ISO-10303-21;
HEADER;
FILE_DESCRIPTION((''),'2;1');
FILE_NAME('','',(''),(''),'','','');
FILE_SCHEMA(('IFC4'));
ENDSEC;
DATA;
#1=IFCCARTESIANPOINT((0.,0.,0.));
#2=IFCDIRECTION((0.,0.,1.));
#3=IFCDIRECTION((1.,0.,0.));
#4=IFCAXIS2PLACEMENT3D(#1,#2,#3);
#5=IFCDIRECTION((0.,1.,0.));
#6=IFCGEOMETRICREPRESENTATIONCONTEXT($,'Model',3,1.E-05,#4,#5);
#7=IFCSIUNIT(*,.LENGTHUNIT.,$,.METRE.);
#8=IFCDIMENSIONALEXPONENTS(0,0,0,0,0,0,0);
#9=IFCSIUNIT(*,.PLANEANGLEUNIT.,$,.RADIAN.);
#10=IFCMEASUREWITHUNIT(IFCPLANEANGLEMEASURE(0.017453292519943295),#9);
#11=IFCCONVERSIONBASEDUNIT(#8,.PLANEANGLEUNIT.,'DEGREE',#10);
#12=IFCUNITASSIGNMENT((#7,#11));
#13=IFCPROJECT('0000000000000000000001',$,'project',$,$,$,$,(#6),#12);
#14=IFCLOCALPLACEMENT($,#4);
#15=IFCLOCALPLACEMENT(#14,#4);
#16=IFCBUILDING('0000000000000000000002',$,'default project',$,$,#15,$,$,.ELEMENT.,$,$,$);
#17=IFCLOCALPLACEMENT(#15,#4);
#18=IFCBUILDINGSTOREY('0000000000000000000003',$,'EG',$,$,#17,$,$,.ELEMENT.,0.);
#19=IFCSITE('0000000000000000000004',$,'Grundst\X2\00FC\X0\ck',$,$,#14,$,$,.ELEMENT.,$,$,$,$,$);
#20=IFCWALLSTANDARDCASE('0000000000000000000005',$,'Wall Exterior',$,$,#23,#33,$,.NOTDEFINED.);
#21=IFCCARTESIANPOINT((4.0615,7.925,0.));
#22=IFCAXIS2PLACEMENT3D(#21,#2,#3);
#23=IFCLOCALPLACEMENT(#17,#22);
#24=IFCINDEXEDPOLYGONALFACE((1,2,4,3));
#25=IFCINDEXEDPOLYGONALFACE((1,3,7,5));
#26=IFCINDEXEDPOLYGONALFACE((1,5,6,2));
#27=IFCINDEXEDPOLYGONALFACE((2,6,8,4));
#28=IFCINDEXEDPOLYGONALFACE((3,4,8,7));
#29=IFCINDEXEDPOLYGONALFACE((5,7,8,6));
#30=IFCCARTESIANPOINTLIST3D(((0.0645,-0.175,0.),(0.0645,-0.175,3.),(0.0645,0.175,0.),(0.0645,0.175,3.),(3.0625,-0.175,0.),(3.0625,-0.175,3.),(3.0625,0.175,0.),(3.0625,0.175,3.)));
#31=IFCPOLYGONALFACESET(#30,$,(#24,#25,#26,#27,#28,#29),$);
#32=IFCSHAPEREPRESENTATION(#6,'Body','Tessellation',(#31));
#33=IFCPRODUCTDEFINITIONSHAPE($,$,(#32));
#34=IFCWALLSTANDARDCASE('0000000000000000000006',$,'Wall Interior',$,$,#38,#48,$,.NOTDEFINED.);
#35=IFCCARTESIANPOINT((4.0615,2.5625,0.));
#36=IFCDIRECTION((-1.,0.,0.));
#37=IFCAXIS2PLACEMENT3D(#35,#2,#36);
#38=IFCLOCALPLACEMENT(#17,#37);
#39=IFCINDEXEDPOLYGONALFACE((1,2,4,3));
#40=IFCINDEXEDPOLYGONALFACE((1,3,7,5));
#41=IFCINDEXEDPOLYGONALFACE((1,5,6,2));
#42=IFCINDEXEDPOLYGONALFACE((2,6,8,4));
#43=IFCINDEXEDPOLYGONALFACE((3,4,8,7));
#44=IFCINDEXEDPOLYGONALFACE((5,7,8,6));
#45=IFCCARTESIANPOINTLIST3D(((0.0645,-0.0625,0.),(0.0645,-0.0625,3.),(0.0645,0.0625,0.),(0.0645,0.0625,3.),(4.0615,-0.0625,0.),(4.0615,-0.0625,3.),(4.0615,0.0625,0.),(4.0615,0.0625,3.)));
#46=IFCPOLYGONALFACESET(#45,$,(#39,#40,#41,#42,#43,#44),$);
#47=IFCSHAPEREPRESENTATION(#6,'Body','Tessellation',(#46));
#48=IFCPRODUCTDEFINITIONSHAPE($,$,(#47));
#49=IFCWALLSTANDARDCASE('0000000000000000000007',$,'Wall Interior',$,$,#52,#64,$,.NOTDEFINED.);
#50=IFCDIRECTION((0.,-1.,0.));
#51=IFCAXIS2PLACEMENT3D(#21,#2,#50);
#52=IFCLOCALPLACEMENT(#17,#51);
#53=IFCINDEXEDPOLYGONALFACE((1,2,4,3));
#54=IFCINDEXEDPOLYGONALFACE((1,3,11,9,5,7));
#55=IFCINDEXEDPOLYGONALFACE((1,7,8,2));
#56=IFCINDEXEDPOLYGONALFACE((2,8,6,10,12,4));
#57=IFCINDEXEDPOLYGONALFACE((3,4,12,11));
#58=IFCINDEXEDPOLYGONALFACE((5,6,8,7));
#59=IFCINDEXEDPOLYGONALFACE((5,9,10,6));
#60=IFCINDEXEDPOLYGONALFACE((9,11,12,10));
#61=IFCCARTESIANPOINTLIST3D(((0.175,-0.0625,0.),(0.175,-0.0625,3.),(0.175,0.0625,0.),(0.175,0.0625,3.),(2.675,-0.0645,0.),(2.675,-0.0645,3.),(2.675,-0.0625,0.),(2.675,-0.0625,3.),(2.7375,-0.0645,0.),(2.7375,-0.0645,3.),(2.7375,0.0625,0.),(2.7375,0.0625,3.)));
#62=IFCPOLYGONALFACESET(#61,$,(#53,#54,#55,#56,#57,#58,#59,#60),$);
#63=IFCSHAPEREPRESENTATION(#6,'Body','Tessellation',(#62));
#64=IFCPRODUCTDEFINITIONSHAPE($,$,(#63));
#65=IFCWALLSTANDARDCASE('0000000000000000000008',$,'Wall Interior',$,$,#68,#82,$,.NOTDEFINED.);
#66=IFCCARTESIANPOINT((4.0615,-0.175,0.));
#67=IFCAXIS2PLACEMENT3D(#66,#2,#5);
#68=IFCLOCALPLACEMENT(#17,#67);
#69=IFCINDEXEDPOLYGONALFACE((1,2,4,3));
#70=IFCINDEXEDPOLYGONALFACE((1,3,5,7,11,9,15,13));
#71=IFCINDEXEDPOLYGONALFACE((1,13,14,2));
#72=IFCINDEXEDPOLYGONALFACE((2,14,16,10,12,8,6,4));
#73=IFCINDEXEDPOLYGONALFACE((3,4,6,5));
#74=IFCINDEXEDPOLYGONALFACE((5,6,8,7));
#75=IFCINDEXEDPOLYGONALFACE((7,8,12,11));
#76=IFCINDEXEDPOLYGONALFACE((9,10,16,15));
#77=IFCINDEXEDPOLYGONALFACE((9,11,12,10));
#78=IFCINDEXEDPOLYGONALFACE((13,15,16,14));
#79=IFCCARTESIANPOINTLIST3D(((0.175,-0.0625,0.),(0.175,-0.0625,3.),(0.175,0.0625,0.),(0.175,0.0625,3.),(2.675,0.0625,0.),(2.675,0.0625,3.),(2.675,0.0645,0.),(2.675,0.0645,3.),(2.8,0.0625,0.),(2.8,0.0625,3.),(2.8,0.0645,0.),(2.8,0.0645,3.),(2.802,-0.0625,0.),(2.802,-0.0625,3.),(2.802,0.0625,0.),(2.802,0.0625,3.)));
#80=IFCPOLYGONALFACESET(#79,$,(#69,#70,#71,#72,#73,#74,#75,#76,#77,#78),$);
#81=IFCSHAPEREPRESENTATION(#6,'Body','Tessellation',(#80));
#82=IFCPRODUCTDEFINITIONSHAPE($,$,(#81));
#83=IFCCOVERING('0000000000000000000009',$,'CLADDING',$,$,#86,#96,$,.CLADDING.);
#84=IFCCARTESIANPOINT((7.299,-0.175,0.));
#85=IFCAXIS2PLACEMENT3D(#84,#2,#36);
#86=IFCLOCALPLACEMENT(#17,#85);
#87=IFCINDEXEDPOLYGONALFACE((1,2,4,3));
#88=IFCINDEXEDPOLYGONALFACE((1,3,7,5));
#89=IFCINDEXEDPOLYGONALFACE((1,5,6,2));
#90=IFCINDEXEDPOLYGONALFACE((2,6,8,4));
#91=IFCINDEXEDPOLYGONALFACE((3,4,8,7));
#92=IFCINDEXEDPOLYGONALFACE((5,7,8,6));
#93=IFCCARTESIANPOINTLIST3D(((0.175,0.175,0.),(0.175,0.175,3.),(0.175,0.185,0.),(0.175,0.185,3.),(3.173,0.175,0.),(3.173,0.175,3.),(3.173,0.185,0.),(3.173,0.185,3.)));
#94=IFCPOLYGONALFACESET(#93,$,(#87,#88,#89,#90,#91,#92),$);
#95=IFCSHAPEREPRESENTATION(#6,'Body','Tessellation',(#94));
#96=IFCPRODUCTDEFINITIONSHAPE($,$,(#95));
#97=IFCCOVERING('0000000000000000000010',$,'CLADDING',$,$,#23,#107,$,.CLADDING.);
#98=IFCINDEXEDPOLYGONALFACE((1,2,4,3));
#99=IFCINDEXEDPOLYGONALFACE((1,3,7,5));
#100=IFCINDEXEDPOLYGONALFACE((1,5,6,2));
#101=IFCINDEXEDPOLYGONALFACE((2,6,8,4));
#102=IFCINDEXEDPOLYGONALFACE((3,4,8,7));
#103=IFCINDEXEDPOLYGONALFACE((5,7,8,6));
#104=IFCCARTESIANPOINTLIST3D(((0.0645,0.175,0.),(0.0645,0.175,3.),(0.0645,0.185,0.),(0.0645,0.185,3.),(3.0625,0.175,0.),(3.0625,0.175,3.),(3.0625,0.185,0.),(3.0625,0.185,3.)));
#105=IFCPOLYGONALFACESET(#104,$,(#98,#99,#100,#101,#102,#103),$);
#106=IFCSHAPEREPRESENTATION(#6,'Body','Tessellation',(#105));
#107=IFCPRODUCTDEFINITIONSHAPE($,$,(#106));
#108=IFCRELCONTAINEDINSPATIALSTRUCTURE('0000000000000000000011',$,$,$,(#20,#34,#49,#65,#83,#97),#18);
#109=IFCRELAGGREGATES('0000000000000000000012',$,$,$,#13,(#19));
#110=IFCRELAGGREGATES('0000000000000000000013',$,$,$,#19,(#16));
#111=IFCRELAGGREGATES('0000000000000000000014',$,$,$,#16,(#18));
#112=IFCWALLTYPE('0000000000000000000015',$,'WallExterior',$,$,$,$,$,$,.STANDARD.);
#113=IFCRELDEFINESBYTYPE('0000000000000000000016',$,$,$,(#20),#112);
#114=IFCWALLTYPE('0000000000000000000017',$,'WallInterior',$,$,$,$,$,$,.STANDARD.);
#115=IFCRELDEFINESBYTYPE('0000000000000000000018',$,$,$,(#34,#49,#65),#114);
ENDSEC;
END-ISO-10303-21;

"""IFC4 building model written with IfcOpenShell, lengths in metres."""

from ifc_helpers import new_model, entity, si_unit, converted_unit, direction, frame, origin_with_axes, place, context, project, spatial, polyline, outline, extrude, type_object, element, save


model = new_model("IFC4")

# Units and contexts
model_context = context("Model", 3, precision=1e-05, world=origin_with_axes(), true_north=direction((0.0, 1.0, 0.0)))
ifc_project = project(units=[si_unit("LENGTHUNIT", "METRE"), converted_unit("PLANEANGLEUNIT", "DEGREE", entity("IfcPlaneAngleMeasure", 0.017453292519943295), si_unit("PLANEANGLEUNIT", "RADIAN"), dimensions=[0, 0, 0, 0, 0, 0, 0])], contexts=[model_context])

# Site, building, storey
site_placement = place(None, origin_with_axes())
site = spatial("IfcSite", under=ifc_project, at=site_placement, Name="Grundstück", CompositionType="ELEMENT")
building_placement = place(site_placement, origin_with_axes())
building = spatial("IfcBuilding", under=site, at=building_placement, Name="default project", CompositionType="ELEMENT")
placement_1 = place(building_placement, origin_with_axes())
storey = spatial("IfcBuildingStorey", under=building, at=placement_1, Name="EG", CompositionType="ELEMENT", Elevation=0.0)

# Walls
wall_type_1 = type_object("IfcWallType", Name="WallExterior", PredefinedType="STANDARD")
placement_2 = place(placement_1, frame((7.299, -0.175, 0.0), z_axis=(0.0, 0.0, 1.0), x_axis=(-1.0, 0.0, 0.0)))
placement_3 = place(placement_1, frame((4.0615, 7.925, 0.0), z_axis=(0.0, 0.0, 1.0), x_axis=(1.0, 0.0, 0.0)))
element("IfcWallStandardCase", 1, at=placement_3, inside=storey, type_object=wall_type_1, Name="Wall Exterior", PredefinedType="NOTDEFINED", context=model_context, shape_type="SweptSolid", body=[
    extrude(outline(polyline([(3.0625, 0.175), (0.0645, 0.175), (0.0645, -0.175), (3.0625, -0.175), (3.0625, 0.175)])), origin_with_axes(), (0.0, 0.0, 1.0), 3.0),
])
wall_type_2 = type_object("IfcWallType", Name="WallInterior", PredefinedType="STANDARD")
wall_1_placement = place(placement_1, frame((4.0615, 2.5625, 0.0), z_axis=(0.0, 0.0, 1.0), x_axis=(-1.0, 0.0, 0.0)))
element("IfcWallStandardCase", 2, at=wall_1_placement, inside=storey, type_object=wall_type_2, Name="Wall Interior", PredefinedType="NOTDEFINED", context=model_context, shape_type="SweptSolid", body=[
    extrude(outline(polyline([(0.0645, -0.0625), (4.0615, -0.0625), (4.0615, 0.0625), (0.0645, 0.0625), (0.0645, -0.0625)])), origin_with_axes(), (0.0, 0.0, 1.0), 3.0),
])
wall_2_placement = place(placement_1, frame((4.0615, 7.925, 0.0), z_axis=(0.0, 0.0, 1.0), x_axis=(0.0, -1.0, 0.0)))
element("IfcWallStandardCase", 3, at=wall_2_placement, inside=storey, type_object=wall_type_2, Name="Wall Interior", PredefinedType="NOTDEFINED", context=model_context, shape_type="SweptSolid", body=[
    extrude(outline(polyline([(2.675, -0.0645), (2.7375, -0.0645), (2.7375, 0.0625), (0.175, 0.0625), (0.175, -0.0625), (2.675, -0.0625), (2.675, -0.0645)])), origin_with_axes(), (0.0, 0.0, 1.0), 3.0),
])
wall_3_placement = place(placement_1, frame((4.0615, -0.175, 0.0), z_axis=(0.0, 0.0, 1.0), x_axis=(0.0, 1.0, 0.0)))
element("IfcWallStandardCase", 4, at=wall_3_placement, inside=storey, type_object=wall_type_2, Name="Wall Interior", PredefinedType="NOTDEFINED", context=model_context, shape_type="SweptSolid", body=[
    extrude(outline(polyline([(2.8, 0.0645), (2.675, 0.0645), (2.675, 0.0625), (0.175, 0.0625), (0.175, -0.0625), (2.802, -0.0625), (2.802, 0.0625), (2.8, 0.0625), (2.8, 0.0645)])), origin_with_axes(), (0.0, 0.0, 1.0), 3.0),
])

# Coverings
element("IfcCovering", 5, at=placement_2, inside=storey, Name="CLADDING", PredefinedType="CLADDING", context=model_context, shape_type="SweptSolid", body=[
    extrude(outline(polyline([(3.173, 0.185), (0.175, 0.185), (0.175, 0.175), (3.173, 0.175), (3.173, 0.185)])), origin_with_axes(), (0.0, 0.0, 1.0), 3.0),
])
element("IfcCovering", 6, at=placement_3, inside=storey, Name="CLADDING", PredefinedType="CLADDING", context=model_context, shape_type="SweptSolid", body=[
    extrude(outline(polyline([(3.0625, 0.185), (0.0645, 0.185), (0.0645, 0.175), (3.0625, 0.175), (3.0625, 0.185)])), origin_with_axes(), (0.0, 0.0, 1.0), 3.0),
])

save(model, "model.ifc")
